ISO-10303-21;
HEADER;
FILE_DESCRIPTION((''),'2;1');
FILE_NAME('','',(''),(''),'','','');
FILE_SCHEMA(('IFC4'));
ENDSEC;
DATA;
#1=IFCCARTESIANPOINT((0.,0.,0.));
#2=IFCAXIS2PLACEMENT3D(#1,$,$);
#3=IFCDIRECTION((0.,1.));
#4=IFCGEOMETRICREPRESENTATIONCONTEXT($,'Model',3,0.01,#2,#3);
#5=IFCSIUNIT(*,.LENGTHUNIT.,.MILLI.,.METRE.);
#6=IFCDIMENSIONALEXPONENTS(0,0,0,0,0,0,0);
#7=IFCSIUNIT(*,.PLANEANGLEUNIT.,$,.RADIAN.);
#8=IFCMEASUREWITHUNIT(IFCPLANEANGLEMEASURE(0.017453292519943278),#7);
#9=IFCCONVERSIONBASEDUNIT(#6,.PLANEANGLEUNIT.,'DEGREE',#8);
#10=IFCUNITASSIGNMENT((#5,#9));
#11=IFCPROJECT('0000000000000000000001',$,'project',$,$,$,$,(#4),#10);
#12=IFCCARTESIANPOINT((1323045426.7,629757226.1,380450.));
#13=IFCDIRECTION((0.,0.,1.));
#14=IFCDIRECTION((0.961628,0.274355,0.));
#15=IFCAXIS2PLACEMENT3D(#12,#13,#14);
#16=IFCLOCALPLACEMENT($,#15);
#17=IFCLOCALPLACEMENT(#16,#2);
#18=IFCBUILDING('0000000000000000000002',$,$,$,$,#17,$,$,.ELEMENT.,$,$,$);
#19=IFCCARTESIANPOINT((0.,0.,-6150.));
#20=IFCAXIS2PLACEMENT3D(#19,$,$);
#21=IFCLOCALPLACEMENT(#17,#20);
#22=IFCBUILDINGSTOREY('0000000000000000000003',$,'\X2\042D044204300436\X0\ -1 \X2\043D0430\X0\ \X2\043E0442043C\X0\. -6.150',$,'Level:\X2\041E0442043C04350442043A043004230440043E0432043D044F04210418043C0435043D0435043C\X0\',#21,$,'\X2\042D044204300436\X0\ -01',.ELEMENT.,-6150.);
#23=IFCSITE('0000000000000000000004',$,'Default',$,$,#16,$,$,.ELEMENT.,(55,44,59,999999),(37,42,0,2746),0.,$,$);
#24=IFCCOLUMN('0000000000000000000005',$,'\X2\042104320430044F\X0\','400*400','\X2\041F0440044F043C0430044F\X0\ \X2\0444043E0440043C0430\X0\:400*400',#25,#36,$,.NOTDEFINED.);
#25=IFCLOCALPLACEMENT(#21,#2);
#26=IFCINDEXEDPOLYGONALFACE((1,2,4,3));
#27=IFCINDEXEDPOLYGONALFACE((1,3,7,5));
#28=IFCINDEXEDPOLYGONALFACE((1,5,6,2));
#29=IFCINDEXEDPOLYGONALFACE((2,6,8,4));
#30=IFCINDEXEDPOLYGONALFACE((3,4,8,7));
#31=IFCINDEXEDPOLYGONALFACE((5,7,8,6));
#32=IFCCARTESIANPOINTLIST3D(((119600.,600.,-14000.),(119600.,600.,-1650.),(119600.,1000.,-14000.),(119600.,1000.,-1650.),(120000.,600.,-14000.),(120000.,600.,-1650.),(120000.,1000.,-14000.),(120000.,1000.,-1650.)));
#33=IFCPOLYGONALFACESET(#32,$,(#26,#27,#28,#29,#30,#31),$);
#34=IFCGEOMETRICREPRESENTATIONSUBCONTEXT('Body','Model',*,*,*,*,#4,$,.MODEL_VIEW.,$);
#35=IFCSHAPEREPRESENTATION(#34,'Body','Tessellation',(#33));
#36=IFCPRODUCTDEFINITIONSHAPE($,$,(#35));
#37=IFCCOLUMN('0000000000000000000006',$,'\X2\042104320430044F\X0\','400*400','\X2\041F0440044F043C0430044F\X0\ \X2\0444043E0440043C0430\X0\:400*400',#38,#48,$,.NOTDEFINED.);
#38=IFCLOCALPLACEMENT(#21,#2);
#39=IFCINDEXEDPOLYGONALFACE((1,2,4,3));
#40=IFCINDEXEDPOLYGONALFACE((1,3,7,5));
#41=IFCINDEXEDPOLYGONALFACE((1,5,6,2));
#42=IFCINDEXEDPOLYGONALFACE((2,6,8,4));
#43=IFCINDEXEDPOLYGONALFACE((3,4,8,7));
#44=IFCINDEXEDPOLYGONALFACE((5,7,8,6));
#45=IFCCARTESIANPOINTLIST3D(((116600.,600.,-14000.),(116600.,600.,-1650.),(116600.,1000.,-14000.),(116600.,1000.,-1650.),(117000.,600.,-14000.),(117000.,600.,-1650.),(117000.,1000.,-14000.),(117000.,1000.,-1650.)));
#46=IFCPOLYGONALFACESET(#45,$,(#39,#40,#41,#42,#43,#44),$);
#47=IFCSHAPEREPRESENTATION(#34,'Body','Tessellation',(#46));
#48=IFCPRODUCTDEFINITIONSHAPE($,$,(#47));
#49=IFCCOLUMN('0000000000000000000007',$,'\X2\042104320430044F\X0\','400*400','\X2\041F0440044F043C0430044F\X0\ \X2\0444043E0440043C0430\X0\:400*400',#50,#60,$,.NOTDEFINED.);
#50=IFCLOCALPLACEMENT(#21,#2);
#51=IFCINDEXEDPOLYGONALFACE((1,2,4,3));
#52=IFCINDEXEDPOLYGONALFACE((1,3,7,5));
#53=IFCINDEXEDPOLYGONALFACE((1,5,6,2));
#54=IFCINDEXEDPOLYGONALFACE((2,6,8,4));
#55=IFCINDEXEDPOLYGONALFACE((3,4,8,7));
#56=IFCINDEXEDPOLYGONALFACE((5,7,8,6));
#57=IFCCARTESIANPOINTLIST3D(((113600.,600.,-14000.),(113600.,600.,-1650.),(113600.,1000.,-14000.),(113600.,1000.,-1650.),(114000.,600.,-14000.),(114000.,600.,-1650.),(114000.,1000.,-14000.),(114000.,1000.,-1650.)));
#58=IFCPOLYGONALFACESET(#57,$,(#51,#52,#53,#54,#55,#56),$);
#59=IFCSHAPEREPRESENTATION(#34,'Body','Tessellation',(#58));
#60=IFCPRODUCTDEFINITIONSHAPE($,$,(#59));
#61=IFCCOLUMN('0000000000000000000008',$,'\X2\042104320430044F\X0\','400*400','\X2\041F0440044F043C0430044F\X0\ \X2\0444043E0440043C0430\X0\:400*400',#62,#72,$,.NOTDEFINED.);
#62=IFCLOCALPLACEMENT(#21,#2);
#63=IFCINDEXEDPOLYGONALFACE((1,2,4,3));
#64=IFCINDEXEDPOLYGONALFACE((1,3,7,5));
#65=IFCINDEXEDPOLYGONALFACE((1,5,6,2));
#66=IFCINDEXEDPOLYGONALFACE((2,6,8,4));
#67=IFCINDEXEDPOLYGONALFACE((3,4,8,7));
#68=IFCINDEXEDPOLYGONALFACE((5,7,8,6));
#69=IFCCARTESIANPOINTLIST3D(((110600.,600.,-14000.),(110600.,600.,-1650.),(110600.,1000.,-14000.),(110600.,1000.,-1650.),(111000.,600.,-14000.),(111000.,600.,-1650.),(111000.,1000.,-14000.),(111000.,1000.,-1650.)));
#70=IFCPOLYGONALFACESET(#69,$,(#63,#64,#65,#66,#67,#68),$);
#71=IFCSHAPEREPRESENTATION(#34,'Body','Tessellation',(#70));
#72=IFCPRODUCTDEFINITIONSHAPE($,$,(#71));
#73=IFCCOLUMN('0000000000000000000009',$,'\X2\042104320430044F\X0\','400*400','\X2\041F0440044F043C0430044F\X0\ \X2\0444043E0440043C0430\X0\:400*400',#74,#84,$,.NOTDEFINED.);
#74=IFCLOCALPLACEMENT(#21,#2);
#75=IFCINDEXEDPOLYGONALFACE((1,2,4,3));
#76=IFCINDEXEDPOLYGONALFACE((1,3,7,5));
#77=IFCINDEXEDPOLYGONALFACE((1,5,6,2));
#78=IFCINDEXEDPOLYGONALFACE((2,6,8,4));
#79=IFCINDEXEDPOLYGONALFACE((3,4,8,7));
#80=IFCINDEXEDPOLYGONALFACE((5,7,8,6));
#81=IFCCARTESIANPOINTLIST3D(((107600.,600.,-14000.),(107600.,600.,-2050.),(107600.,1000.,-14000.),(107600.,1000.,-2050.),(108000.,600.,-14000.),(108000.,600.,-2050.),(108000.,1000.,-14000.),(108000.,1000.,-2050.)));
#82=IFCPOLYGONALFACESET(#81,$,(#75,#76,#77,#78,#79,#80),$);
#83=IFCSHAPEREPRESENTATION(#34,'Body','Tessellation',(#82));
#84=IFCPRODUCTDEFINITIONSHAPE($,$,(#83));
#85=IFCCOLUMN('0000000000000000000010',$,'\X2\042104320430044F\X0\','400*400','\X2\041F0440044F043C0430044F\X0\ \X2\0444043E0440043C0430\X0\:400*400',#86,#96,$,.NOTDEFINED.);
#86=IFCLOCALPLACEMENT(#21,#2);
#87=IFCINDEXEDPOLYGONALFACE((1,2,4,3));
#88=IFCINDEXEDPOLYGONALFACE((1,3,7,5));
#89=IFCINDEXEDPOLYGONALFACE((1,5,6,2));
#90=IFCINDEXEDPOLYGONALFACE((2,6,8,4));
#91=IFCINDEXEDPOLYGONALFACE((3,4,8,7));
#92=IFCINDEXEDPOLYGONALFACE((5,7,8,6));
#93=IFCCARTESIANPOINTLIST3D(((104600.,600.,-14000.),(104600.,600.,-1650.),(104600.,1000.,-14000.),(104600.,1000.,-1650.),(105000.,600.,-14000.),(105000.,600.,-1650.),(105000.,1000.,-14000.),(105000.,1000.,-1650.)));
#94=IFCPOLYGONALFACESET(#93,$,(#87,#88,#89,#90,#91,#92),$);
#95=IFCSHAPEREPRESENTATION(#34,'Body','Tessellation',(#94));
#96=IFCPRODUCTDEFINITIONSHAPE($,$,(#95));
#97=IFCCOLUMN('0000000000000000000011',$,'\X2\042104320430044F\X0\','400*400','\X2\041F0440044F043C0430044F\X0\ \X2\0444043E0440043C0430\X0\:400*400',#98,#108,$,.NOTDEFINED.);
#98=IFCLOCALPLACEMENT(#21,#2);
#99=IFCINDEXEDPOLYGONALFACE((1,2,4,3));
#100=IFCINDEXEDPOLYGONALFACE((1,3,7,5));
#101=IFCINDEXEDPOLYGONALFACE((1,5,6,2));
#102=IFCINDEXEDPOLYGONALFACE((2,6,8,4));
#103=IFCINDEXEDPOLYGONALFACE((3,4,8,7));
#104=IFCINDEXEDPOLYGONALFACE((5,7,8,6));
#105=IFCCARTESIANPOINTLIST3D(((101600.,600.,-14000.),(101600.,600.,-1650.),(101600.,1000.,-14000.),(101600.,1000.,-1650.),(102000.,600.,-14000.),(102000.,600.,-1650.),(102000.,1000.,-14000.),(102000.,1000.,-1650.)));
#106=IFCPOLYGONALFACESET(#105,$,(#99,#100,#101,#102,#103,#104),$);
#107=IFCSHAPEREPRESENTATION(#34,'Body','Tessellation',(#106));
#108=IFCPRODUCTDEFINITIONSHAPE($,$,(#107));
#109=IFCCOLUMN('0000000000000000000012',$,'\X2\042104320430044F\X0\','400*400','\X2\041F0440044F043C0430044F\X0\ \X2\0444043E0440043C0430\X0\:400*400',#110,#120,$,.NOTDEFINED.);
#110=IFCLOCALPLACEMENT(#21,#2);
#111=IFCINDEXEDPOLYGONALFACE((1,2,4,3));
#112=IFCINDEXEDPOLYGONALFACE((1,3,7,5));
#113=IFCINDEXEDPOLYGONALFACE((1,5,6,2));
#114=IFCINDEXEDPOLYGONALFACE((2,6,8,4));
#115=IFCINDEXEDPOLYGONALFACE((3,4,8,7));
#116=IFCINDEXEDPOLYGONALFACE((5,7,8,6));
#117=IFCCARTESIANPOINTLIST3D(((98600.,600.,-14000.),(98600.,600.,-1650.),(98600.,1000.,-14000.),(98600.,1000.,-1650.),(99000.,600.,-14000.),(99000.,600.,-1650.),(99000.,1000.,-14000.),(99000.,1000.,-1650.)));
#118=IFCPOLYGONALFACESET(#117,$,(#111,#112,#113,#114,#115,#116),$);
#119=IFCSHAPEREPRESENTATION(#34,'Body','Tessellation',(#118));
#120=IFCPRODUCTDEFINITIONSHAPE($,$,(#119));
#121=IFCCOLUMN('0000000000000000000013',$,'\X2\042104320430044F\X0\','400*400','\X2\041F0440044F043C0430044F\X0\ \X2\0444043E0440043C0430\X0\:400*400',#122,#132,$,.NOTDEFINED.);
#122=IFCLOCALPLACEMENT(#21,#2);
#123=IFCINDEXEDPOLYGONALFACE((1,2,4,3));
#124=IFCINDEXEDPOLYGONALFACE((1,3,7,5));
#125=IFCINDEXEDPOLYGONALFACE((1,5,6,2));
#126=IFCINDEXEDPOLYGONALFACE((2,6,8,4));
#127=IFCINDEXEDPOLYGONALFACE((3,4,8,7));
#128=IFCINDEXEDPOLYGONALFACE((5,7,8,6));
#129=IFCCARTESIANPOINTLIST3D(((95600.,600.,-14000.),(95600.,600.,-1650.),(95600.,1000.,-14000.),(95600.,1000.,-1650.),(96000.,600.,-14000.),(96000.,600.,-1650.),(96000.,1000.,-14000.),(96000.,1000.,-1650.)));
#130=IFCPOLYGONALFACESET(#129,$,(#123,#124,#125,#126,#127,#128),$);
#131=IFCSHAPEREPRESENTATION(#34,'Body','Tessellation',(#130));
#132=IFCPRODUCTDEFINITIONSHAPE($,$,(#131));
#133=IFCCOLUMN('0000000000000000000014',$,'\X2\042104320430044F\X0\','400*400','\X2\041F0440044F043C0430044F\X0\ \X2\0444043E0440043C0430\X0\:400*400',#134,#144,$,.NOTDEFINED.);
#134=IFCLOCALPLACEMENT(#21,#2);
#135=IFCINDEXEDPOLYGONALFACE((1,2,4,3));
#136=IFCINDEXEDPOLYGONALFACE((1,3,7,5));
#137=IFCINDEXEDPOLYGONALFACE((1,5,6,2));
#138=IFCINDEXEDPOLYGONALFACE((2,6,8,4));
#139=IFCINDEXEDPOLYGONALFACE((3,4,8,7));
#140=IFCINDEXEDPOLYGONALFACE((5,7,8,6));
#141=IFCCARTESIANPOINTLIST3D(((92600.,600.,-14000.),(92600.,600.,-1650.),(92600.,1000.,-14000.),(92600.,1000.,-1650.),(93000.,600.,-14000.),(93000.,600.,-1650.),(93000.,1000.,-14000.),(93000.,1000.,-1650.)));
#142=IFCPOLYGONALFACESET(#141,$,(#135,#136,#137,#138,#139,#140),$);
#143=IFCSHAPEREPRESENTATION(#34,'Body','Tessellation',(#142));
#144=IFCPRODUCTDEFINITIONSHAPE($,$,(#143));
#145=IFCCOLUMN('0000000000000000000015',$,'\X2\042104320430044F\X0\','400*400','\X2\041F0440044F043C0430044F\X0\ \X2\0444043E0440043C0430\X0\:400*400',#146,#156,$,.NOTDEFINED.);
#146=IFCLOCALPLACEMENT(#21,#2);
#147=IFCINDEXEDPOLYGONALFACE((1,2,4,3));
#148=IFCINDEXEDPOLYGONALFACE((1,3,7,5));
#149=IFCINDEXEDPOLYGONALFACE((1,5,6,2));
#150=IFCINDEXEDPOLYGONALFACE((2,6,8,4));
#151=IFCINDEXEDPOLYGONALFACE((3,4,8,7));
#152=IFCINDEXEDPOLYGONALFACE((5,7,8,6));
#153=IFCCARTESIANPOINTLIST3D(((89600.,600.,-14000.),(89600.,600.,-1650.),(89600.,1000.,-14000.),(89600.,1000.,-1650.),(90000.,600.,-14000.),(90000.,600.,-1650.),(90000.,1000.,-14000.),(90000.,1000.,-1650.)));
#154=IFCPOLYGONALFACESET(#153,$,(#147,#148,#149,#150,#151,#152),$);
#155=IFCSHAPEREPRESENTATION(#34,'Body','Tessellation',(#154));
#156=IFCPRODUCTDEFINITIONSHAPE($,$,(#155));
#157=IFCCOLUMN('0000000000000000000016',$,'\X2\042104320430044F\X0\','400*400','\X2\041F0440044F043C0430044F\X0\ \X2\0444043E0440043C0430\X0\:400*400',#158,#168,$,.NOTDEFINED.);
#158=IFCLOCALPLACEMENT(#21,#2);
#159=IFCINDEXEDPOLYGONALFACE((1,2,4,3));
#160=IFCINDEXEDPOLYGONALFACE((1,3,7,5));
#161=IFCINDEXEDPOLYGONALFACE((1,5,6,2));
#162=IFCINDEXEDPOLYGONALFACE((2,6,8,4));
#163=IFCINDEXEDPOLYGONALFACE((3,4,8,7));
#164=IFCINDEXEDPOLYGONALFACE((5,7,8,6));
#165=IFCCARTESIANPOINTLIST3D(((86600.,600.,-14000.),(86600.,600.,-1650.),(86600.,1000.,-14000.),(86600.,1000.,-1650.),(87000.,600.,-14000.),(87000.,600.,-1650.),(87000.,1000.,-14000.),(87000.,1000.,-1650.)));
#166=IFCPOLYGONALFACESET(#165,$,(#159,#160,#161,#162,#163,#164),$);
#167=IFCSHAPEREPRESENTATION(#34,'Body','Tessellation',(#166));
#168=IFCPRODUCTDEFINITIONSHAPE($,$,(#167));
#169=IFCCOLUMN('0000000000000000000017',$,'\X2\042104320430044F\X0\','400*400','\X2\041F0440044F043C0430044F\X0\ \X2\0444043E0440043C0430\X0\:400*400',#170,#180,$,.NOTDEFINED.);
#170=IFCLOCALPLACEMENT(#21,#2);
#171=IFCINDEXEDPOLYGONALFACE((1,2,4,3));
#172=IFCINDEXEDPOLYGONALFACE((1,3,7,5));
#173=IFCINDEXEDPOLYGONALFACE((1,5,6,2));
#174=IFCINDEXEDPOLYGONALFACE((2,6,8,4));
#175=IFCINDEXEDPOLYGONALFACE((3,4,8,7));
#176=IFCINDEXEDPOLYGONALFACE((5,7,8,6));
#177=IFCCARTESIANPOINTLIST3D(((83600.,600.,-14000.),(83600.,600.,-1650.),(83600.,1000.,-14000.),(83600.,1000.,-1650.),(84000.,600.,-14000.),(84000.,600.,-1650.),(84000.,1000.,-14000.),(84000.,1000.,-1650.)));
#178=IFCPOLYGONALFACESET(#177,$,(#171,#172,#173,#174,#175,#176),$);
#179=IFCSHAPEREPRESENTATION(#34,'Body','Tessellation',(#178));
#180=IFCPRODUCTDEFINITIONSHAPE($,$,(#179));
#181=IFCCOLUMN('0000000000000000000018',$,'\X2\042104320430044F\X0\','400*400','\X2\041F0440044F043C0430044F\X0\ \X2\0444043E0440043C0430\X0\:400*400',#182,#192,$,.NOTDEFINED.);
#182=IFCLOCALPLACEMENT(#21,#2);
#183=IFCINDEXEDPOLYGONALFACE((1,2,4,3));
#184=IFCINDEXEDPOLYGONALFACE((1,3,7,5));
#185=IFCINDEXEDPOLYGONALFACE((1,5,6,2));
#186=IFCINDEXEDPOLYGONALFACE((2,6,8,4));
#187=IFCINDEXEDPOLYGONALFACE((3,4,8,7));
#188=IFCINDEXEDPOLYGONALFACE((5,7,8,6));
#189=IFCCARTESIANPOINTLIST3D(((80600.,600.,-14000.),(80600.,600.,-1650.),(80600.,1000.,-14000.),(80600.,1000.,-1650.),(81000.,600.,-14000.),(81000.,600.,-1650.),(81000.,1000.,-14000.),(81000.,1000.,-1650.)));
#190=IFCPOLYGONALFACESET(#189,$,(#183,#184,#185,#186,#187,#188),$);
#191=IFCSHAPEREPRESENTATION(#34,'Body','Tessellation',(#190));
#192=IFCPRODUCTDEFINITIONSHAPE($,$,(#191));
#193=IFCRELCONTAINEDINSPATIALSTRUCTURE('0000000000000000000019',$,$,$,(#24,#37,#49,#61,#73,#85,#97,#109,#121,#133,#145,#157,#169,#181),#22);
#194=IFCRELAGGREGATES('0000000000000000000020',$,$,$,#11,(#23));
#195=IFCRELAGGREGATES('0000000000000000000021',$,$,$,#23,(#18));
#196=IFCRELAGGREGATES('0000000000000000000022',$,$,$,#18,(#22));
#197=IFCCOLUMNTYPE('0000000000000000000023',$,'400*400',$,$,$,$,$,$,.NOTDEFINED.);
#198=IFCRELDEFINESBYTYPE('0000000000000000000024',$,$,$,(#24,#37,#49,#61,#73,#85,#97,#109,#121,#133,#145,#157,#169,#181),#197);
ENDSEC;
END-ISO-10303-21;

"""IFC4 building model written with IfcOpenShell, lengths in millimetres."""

from ifc_helpers import new_model, entity, si_unit, converted_unit, direction, frame, origin, place, context, subcontext, project, spatial, indexed_curve, outline, extrude, type_object, element, save


model = new_model("IFC4")

# Units and contexts
model_context = context("Model", 3, precision=0.01, world=origin(), true_north=direction((0.0, 1.0)))
body_context = subcontext(model_context, "Body", "Model", "MODEL_VIEW")
ifc_project = project(units=[si_unit("LENGTHUNIT", "METRE", prefix="MILLI"), converted_unit("PLANEANGLEUNIT", "DEGREE", entity("IfcPlaneAngleMeasure", 0.017453292519943278), si_unit("PLANEANGLEUNIT", "RADIAN"), dimensions=[0, 0, 0, 0, 0, 0, 0])], contexts=[model_context])

# Site, building, storey
site_placement = place(None, frame((1323045426.7, 629757226.1, 380450.0), z_axis=(0.0, 0.0, 1.0), x_axis=(0.961628, 0.274355, 0.0)))
site = spatial("IfcSite", under=ifc_project, at=site_placement, Name="Default", CompositionType="ELEMENT", RefLatitude=(55, 44, 59, 999999), RefLongitude=(37, 42, 0, 2746), RefElevation=0.0)
building_placement = place(site_placement, origin())
building = spatial("IfcBuilding", under=site, at=building_placement, CompositionType="ELEMENT")
storey_placement = place(building_placement, frame((0.0, 0.0, -6150.0)))
storey = spatial("IfcBuildingStorey", under=building, at=storey_placement, Name="Этаж -1 на отм. -6.150", ObjectType="Level:ОтметкаУровняСИменем", LongName="Этаж -01", CompositionType="ELEMENT", Elevation=-6150.0)

# Columns
column_type = type_object("IfcColumnType", Name="400*400", PredefinedType="NOTDEFINED")
column_1_placement = place(storey_placement, origin())
element("IfcColumn", 1, at=column_1_placement, inside=storey, type_object=column_type, Name="Свая", Description="400*400", ObjectType="Прямая форма:400*400", PredefinedType="NOTDEFINED", context=body_context, shape_type="SweptSolid", body=[
    extrude(outline(indexed_curve([(-200.0, -200.0), (200.0, -200.0), (200.0, 200.0), (-200.0, 200.0), (-200.0, -200.0)], self_intersect=False)), frame((119800.0, 800.0, -14000.0), z_axis=(0.0, 0.0, 1.0), x_axis=(0.0, 1.0, 0.0)), (0.0, 0.0, 1.0), 12350.0),
])
column_2_placement = place(storey_placement, origin())
element("IfcColumn", 2, at=column_2_placement, inside=storey, type_object=column_type, Name="Свая", Description="400*400", ObjectType="Прямая форма:400*400", PredefinedType="NOTDEFINED", context=body_context, shape_type="SweptSolid", body=[
    extrude(outline(indexed_curve([(-200.0, -200.0), (200.0, -200.0), (200.0, 200.0), (-200.0, 200.0), (-200.0, -200.0)], self_intersect=False)), frame((116800.0, 800.0, -14000.0), z_axis=(0.0, 0.0, 1.0), x_axis=(0.0, 1.0, 0.0)), (0.0, 0.0, 1.0), 12350.0),
])
column_3_placement = place(storey_placement, origin())
element("IfcColumn", 3, at=column_3_placement, inside=storey, type_object=column_type, Name="Свая", Description="400*400", ObjectType="Прямая форма:400*400", PredefinedType="NOTDEFINED", context=body_context, shape_type="SweptSolid", body=[
    extrude(outline(indexed_curve([(-200.0, -200.0), (200.0, -200.0), (200.0, 200.0), (-200.0, 200.0), (-200.0, -200.0)], self_intersect=False)), frame((113800.0, 800.0, -14000.0), z_axis=(0.0, 0.0, 1.0), x_axis=(0.0, 1.0, 0.0)), (0.0, 0.0, 1.0), 12350.0),
])
column_4_placement = place(storey_placement, origin())
element("IfcColumn", 4, at=column_4_placement, inside=storey, type_object=column_type, Name="Свая", Description="400*400", ObjectType="Прямая форма:400*400", PredefinedType="NOTDEFINED", context=body_context, shape_type="SweptSolid", body=[
    extrude(outline(indexed_curve([(-200.0, -200.0), (200.0, -200.0), (200.0, 200.0), (-200.0, 200.0), (-200.0, -200.0)], self_intersect=False)), frame((110800.0, 800.0, -14000.0), z_axis=(0.0, 0.0, 1.0), x_axis=(0.0, 1.0, 0.0)), (0.0, 0.0, 1.0), 12350.0),
])
column_5_placement = place(storey_placement, origin())
element("IfcColumn", 5, at=column_5_placement, inside=storey, type_object=column_type, Name="Свая", Description="400*400", ObjectType="Прямая форма:400*400", PredefinedType="NOTDEFINED", context=body_context, shape_type="SweptSolid", body=[
    extrude(outline(indexed_curve([(-200.0, -200.0), (200.0, -200.0), (200.0, 200.0), (-200.0, 200.0), (-200.0, -200.0)], self_intersect=False)), frame((107800.0, 800.0, -14000.0), z_axis=(0.0, 0.0, 1.0), x_axis=(0.0, 1.0, 0.0)), (0.0, 0.0, 1.0), 11950.0),
])
column_6_placement = place(storey_placement, origin())
element("IfcColumn", 6, at=column_6_placement, inside=storey, type_object=column_type, Name="Свая", Description="400*400", ObjectType="Прямая форма:400*400", PredefinedType="NOTDEFINED", context=body_context, shape_type="SweptSolid", body=[
    extrude(outline(indexed_curve([(-200.0, -200.0), (200.0, -200.0), (200.0, 200.0), (-200.0, 200.0), (-200.0, -200.0)], self_intersect=False)), frame((104800.0, 800.0, -14000.0), z_axis=(0.0, 0.0, 1.0), x_axis=(0.0, 1.0, 0.0)), (0.0, 0.0, 1.0), 12350.0),
])
column_7_placement = place(storey_placement, origin())
element("IfcColumn", 7, at=column_7_placement, inside=storey, type_object=column_type, Name="Свая", Description="400*400", ObjectType="Прямая форма:400*400", PredefinedType="NOTDEFINED", context=body_context, shape_type="SweptSolid", body=[
    extrude(outline(indexed_curve([(-200.0, -200.0), (200.0, -200.0), (200.0, 200.0), (-200.0, 200.0), (-200.0, -200.0)], self_intersect=False)), frame((101800.0, 800.0, -14000.0), z_axis=(0.0, 0.0, 1.0), x_axis=(0.0, 1.0, 0.0)), (0.0, 0.0, 1.0), 12350.0),
])
column_8_placement = place(storey_placement, origin())
element("IfcColumn", 8, at=column_8_placement, inside=storey, type_object=column_type, Name="Свая", Description="400*400", ObjectType="Прямая форма:400*400", PredefinedType="NOTDEFINED", context=body_context, shape_type="SweptSolid", body=[
    extrude(outline(indexed_curve([(-200.0, -200.0), (200.0, -200.0), (200.0, 200.0), (-200.0, 200.0), (-200.0, -200.0)], self_intersect=False)), frame((98800.0, 800.0, -14000.0), z_axis=(0.0, 0.0, 1.0), x_axis=(0.0, 1.0, 0.0)), (0.0, 0.0, 1.0), 12350.0),
])
column_9_placement = place(storey_placement, origin())
element("IfcColumn", 9, at=column_9_placement, inside=storey, type_object=column_type, Name="Свая", Description="400*400", ObjectType="Прямая форма:400*400", PredefinedType="NOTDEFINED", context=body_context, shape_type="SweptSolid", body=[
    extrude(outline(indexed_curve([(-200.0, -200.0), (200.0, -200.0), (200.0, 200.0), (-200.0, 200.0), (-200.0, -200.0)], self_intersect=False)), frame((95800.0, 800.0, -14000.0), z_axis=(0.0, 0.0, 1.0), x_axis=(0.0, 1.0, 0.0)), (0.0, 0.0, 1.0), 12350.0),
])
column_10_placement = place(storey_placement, origin())
element("IfcColumn", 10, at=column_10_placement, inside=storey, type_object=column_type, Name="Свая", Description="400*400", ObjectType="Прямая форма:400*400", PredefinedType="NOTDEFINED", context=body_context, shape_type="SweptSolid", body=[
    extrude(outline(indexed_curve([(-200.0, -200.0), (200.0, -200.0), (200.0, 200.0), (-200.0, 200.0), (-200.0, -200.0)], self_intersect=False)), frame((92800.0, 800.0, -14000.0), z_axis=(0.0, 0.0, 1.0), x_axis=(0.0, 1.0, 0.0)), (0.0, 0.0, 1.0), 12350.0),
])
column_11_placement = place(storey_placement, origin())
element("IfcColumn", 11, at=column_11_placement, inside=storey, type_object=column_type, Name="Свая", Description="400*400", ObjectType="Прямая форма:400*400", PredefinedType="NOTDEFINED", context=body_context, shape_type="SweptSolid", body=[
    extrude(outline(indexed_curve([(-200.0, -200.0), (200.0, -200.0), (200.0, 200.0), (-200.0, 200.0), (-200.0, -200.0)], self_intersect=False)), frame((89800.0, 800.0, -14000.0), z_axis=(0.0, 0.0, 1.0), x_axis=(0.0, 1.0, 0.0)), (0.0, 0.0, 1.0), 12350.0),
])
column_12_placement = place(storey_placement, origin())
element("IfcColumn", 12, at=column_12_placement, inside=storey, type_object=column_type, Name="Свая", Description="400*400", ObjectType="Прямая форма:400*400", PredefinedType="NOTDEFINED", context=body_context, shape_type="SweptSolid", body=[
    extrude(outline(indexed_curve([(-200.0, -200.0), (200.0, -200.0), (200.0, 200.0), (-200.0, 200.0), (-200.0, -200.0)], self_intersect=False)), frame((86800.0, 800.0, -14000.0), z_axis=(0.0, 0.0, 1.0), x_axis=(0.0, 1.0, 0.0)), (0.0, 0.0, 1.0), 12350.0),
])
column_13_placement = place(storey_placement, origin())
element("IfcColumn", 13, at=column_13_placement, inside=storey, type_object=column_type, Name="Свая", Description="400*400", ObjectType="Прямая форма:400*400", PredefinedType="NOTDEFINED", context=body_context, shape_type="SweptSolid", body=[
    extrude(outline(indexed_curve([(-200.0, -200.0), (200.0, -200.0), (200.0, 200.0), (-200.0, 200.0), (-200.0, -200.0)], self_intersect=False)), frame((83800.0, 800.0, -14000.0), z_axis=(0.0, 0.0, 1.0), x_axis=(0.0, 1.0, 0.0)), (0.0, 0.0, 1.0), 12350.0),
])
column_14_placement = place(storey_placement, origin())
element("IfcColumn", 14, at=column_14_placement, inside=storey, type_object=column_type, Name="Свая", Description="400*400", ObjectType="Прямая форма:400*400", PredefinedType="NOTDEFINED", context=body_context, shape_type="SweptSolid", body=[
    extrude(outline(indexed_curve([(-200.0, -200.0), (200.0, -200.0), (200.0, 200.0), (-200.0, 200.0), (-200.0, -200.0)], self_intersect=False)), frame((80800.0, 800.0, -14000.0), z_axis=(0.0, 0.0, 1.0), x_axis=(0.0, 1.0, 0.0)), (0.0, 0.0, 1.0), 12350.0),
])

save(model, "model.ifc")
